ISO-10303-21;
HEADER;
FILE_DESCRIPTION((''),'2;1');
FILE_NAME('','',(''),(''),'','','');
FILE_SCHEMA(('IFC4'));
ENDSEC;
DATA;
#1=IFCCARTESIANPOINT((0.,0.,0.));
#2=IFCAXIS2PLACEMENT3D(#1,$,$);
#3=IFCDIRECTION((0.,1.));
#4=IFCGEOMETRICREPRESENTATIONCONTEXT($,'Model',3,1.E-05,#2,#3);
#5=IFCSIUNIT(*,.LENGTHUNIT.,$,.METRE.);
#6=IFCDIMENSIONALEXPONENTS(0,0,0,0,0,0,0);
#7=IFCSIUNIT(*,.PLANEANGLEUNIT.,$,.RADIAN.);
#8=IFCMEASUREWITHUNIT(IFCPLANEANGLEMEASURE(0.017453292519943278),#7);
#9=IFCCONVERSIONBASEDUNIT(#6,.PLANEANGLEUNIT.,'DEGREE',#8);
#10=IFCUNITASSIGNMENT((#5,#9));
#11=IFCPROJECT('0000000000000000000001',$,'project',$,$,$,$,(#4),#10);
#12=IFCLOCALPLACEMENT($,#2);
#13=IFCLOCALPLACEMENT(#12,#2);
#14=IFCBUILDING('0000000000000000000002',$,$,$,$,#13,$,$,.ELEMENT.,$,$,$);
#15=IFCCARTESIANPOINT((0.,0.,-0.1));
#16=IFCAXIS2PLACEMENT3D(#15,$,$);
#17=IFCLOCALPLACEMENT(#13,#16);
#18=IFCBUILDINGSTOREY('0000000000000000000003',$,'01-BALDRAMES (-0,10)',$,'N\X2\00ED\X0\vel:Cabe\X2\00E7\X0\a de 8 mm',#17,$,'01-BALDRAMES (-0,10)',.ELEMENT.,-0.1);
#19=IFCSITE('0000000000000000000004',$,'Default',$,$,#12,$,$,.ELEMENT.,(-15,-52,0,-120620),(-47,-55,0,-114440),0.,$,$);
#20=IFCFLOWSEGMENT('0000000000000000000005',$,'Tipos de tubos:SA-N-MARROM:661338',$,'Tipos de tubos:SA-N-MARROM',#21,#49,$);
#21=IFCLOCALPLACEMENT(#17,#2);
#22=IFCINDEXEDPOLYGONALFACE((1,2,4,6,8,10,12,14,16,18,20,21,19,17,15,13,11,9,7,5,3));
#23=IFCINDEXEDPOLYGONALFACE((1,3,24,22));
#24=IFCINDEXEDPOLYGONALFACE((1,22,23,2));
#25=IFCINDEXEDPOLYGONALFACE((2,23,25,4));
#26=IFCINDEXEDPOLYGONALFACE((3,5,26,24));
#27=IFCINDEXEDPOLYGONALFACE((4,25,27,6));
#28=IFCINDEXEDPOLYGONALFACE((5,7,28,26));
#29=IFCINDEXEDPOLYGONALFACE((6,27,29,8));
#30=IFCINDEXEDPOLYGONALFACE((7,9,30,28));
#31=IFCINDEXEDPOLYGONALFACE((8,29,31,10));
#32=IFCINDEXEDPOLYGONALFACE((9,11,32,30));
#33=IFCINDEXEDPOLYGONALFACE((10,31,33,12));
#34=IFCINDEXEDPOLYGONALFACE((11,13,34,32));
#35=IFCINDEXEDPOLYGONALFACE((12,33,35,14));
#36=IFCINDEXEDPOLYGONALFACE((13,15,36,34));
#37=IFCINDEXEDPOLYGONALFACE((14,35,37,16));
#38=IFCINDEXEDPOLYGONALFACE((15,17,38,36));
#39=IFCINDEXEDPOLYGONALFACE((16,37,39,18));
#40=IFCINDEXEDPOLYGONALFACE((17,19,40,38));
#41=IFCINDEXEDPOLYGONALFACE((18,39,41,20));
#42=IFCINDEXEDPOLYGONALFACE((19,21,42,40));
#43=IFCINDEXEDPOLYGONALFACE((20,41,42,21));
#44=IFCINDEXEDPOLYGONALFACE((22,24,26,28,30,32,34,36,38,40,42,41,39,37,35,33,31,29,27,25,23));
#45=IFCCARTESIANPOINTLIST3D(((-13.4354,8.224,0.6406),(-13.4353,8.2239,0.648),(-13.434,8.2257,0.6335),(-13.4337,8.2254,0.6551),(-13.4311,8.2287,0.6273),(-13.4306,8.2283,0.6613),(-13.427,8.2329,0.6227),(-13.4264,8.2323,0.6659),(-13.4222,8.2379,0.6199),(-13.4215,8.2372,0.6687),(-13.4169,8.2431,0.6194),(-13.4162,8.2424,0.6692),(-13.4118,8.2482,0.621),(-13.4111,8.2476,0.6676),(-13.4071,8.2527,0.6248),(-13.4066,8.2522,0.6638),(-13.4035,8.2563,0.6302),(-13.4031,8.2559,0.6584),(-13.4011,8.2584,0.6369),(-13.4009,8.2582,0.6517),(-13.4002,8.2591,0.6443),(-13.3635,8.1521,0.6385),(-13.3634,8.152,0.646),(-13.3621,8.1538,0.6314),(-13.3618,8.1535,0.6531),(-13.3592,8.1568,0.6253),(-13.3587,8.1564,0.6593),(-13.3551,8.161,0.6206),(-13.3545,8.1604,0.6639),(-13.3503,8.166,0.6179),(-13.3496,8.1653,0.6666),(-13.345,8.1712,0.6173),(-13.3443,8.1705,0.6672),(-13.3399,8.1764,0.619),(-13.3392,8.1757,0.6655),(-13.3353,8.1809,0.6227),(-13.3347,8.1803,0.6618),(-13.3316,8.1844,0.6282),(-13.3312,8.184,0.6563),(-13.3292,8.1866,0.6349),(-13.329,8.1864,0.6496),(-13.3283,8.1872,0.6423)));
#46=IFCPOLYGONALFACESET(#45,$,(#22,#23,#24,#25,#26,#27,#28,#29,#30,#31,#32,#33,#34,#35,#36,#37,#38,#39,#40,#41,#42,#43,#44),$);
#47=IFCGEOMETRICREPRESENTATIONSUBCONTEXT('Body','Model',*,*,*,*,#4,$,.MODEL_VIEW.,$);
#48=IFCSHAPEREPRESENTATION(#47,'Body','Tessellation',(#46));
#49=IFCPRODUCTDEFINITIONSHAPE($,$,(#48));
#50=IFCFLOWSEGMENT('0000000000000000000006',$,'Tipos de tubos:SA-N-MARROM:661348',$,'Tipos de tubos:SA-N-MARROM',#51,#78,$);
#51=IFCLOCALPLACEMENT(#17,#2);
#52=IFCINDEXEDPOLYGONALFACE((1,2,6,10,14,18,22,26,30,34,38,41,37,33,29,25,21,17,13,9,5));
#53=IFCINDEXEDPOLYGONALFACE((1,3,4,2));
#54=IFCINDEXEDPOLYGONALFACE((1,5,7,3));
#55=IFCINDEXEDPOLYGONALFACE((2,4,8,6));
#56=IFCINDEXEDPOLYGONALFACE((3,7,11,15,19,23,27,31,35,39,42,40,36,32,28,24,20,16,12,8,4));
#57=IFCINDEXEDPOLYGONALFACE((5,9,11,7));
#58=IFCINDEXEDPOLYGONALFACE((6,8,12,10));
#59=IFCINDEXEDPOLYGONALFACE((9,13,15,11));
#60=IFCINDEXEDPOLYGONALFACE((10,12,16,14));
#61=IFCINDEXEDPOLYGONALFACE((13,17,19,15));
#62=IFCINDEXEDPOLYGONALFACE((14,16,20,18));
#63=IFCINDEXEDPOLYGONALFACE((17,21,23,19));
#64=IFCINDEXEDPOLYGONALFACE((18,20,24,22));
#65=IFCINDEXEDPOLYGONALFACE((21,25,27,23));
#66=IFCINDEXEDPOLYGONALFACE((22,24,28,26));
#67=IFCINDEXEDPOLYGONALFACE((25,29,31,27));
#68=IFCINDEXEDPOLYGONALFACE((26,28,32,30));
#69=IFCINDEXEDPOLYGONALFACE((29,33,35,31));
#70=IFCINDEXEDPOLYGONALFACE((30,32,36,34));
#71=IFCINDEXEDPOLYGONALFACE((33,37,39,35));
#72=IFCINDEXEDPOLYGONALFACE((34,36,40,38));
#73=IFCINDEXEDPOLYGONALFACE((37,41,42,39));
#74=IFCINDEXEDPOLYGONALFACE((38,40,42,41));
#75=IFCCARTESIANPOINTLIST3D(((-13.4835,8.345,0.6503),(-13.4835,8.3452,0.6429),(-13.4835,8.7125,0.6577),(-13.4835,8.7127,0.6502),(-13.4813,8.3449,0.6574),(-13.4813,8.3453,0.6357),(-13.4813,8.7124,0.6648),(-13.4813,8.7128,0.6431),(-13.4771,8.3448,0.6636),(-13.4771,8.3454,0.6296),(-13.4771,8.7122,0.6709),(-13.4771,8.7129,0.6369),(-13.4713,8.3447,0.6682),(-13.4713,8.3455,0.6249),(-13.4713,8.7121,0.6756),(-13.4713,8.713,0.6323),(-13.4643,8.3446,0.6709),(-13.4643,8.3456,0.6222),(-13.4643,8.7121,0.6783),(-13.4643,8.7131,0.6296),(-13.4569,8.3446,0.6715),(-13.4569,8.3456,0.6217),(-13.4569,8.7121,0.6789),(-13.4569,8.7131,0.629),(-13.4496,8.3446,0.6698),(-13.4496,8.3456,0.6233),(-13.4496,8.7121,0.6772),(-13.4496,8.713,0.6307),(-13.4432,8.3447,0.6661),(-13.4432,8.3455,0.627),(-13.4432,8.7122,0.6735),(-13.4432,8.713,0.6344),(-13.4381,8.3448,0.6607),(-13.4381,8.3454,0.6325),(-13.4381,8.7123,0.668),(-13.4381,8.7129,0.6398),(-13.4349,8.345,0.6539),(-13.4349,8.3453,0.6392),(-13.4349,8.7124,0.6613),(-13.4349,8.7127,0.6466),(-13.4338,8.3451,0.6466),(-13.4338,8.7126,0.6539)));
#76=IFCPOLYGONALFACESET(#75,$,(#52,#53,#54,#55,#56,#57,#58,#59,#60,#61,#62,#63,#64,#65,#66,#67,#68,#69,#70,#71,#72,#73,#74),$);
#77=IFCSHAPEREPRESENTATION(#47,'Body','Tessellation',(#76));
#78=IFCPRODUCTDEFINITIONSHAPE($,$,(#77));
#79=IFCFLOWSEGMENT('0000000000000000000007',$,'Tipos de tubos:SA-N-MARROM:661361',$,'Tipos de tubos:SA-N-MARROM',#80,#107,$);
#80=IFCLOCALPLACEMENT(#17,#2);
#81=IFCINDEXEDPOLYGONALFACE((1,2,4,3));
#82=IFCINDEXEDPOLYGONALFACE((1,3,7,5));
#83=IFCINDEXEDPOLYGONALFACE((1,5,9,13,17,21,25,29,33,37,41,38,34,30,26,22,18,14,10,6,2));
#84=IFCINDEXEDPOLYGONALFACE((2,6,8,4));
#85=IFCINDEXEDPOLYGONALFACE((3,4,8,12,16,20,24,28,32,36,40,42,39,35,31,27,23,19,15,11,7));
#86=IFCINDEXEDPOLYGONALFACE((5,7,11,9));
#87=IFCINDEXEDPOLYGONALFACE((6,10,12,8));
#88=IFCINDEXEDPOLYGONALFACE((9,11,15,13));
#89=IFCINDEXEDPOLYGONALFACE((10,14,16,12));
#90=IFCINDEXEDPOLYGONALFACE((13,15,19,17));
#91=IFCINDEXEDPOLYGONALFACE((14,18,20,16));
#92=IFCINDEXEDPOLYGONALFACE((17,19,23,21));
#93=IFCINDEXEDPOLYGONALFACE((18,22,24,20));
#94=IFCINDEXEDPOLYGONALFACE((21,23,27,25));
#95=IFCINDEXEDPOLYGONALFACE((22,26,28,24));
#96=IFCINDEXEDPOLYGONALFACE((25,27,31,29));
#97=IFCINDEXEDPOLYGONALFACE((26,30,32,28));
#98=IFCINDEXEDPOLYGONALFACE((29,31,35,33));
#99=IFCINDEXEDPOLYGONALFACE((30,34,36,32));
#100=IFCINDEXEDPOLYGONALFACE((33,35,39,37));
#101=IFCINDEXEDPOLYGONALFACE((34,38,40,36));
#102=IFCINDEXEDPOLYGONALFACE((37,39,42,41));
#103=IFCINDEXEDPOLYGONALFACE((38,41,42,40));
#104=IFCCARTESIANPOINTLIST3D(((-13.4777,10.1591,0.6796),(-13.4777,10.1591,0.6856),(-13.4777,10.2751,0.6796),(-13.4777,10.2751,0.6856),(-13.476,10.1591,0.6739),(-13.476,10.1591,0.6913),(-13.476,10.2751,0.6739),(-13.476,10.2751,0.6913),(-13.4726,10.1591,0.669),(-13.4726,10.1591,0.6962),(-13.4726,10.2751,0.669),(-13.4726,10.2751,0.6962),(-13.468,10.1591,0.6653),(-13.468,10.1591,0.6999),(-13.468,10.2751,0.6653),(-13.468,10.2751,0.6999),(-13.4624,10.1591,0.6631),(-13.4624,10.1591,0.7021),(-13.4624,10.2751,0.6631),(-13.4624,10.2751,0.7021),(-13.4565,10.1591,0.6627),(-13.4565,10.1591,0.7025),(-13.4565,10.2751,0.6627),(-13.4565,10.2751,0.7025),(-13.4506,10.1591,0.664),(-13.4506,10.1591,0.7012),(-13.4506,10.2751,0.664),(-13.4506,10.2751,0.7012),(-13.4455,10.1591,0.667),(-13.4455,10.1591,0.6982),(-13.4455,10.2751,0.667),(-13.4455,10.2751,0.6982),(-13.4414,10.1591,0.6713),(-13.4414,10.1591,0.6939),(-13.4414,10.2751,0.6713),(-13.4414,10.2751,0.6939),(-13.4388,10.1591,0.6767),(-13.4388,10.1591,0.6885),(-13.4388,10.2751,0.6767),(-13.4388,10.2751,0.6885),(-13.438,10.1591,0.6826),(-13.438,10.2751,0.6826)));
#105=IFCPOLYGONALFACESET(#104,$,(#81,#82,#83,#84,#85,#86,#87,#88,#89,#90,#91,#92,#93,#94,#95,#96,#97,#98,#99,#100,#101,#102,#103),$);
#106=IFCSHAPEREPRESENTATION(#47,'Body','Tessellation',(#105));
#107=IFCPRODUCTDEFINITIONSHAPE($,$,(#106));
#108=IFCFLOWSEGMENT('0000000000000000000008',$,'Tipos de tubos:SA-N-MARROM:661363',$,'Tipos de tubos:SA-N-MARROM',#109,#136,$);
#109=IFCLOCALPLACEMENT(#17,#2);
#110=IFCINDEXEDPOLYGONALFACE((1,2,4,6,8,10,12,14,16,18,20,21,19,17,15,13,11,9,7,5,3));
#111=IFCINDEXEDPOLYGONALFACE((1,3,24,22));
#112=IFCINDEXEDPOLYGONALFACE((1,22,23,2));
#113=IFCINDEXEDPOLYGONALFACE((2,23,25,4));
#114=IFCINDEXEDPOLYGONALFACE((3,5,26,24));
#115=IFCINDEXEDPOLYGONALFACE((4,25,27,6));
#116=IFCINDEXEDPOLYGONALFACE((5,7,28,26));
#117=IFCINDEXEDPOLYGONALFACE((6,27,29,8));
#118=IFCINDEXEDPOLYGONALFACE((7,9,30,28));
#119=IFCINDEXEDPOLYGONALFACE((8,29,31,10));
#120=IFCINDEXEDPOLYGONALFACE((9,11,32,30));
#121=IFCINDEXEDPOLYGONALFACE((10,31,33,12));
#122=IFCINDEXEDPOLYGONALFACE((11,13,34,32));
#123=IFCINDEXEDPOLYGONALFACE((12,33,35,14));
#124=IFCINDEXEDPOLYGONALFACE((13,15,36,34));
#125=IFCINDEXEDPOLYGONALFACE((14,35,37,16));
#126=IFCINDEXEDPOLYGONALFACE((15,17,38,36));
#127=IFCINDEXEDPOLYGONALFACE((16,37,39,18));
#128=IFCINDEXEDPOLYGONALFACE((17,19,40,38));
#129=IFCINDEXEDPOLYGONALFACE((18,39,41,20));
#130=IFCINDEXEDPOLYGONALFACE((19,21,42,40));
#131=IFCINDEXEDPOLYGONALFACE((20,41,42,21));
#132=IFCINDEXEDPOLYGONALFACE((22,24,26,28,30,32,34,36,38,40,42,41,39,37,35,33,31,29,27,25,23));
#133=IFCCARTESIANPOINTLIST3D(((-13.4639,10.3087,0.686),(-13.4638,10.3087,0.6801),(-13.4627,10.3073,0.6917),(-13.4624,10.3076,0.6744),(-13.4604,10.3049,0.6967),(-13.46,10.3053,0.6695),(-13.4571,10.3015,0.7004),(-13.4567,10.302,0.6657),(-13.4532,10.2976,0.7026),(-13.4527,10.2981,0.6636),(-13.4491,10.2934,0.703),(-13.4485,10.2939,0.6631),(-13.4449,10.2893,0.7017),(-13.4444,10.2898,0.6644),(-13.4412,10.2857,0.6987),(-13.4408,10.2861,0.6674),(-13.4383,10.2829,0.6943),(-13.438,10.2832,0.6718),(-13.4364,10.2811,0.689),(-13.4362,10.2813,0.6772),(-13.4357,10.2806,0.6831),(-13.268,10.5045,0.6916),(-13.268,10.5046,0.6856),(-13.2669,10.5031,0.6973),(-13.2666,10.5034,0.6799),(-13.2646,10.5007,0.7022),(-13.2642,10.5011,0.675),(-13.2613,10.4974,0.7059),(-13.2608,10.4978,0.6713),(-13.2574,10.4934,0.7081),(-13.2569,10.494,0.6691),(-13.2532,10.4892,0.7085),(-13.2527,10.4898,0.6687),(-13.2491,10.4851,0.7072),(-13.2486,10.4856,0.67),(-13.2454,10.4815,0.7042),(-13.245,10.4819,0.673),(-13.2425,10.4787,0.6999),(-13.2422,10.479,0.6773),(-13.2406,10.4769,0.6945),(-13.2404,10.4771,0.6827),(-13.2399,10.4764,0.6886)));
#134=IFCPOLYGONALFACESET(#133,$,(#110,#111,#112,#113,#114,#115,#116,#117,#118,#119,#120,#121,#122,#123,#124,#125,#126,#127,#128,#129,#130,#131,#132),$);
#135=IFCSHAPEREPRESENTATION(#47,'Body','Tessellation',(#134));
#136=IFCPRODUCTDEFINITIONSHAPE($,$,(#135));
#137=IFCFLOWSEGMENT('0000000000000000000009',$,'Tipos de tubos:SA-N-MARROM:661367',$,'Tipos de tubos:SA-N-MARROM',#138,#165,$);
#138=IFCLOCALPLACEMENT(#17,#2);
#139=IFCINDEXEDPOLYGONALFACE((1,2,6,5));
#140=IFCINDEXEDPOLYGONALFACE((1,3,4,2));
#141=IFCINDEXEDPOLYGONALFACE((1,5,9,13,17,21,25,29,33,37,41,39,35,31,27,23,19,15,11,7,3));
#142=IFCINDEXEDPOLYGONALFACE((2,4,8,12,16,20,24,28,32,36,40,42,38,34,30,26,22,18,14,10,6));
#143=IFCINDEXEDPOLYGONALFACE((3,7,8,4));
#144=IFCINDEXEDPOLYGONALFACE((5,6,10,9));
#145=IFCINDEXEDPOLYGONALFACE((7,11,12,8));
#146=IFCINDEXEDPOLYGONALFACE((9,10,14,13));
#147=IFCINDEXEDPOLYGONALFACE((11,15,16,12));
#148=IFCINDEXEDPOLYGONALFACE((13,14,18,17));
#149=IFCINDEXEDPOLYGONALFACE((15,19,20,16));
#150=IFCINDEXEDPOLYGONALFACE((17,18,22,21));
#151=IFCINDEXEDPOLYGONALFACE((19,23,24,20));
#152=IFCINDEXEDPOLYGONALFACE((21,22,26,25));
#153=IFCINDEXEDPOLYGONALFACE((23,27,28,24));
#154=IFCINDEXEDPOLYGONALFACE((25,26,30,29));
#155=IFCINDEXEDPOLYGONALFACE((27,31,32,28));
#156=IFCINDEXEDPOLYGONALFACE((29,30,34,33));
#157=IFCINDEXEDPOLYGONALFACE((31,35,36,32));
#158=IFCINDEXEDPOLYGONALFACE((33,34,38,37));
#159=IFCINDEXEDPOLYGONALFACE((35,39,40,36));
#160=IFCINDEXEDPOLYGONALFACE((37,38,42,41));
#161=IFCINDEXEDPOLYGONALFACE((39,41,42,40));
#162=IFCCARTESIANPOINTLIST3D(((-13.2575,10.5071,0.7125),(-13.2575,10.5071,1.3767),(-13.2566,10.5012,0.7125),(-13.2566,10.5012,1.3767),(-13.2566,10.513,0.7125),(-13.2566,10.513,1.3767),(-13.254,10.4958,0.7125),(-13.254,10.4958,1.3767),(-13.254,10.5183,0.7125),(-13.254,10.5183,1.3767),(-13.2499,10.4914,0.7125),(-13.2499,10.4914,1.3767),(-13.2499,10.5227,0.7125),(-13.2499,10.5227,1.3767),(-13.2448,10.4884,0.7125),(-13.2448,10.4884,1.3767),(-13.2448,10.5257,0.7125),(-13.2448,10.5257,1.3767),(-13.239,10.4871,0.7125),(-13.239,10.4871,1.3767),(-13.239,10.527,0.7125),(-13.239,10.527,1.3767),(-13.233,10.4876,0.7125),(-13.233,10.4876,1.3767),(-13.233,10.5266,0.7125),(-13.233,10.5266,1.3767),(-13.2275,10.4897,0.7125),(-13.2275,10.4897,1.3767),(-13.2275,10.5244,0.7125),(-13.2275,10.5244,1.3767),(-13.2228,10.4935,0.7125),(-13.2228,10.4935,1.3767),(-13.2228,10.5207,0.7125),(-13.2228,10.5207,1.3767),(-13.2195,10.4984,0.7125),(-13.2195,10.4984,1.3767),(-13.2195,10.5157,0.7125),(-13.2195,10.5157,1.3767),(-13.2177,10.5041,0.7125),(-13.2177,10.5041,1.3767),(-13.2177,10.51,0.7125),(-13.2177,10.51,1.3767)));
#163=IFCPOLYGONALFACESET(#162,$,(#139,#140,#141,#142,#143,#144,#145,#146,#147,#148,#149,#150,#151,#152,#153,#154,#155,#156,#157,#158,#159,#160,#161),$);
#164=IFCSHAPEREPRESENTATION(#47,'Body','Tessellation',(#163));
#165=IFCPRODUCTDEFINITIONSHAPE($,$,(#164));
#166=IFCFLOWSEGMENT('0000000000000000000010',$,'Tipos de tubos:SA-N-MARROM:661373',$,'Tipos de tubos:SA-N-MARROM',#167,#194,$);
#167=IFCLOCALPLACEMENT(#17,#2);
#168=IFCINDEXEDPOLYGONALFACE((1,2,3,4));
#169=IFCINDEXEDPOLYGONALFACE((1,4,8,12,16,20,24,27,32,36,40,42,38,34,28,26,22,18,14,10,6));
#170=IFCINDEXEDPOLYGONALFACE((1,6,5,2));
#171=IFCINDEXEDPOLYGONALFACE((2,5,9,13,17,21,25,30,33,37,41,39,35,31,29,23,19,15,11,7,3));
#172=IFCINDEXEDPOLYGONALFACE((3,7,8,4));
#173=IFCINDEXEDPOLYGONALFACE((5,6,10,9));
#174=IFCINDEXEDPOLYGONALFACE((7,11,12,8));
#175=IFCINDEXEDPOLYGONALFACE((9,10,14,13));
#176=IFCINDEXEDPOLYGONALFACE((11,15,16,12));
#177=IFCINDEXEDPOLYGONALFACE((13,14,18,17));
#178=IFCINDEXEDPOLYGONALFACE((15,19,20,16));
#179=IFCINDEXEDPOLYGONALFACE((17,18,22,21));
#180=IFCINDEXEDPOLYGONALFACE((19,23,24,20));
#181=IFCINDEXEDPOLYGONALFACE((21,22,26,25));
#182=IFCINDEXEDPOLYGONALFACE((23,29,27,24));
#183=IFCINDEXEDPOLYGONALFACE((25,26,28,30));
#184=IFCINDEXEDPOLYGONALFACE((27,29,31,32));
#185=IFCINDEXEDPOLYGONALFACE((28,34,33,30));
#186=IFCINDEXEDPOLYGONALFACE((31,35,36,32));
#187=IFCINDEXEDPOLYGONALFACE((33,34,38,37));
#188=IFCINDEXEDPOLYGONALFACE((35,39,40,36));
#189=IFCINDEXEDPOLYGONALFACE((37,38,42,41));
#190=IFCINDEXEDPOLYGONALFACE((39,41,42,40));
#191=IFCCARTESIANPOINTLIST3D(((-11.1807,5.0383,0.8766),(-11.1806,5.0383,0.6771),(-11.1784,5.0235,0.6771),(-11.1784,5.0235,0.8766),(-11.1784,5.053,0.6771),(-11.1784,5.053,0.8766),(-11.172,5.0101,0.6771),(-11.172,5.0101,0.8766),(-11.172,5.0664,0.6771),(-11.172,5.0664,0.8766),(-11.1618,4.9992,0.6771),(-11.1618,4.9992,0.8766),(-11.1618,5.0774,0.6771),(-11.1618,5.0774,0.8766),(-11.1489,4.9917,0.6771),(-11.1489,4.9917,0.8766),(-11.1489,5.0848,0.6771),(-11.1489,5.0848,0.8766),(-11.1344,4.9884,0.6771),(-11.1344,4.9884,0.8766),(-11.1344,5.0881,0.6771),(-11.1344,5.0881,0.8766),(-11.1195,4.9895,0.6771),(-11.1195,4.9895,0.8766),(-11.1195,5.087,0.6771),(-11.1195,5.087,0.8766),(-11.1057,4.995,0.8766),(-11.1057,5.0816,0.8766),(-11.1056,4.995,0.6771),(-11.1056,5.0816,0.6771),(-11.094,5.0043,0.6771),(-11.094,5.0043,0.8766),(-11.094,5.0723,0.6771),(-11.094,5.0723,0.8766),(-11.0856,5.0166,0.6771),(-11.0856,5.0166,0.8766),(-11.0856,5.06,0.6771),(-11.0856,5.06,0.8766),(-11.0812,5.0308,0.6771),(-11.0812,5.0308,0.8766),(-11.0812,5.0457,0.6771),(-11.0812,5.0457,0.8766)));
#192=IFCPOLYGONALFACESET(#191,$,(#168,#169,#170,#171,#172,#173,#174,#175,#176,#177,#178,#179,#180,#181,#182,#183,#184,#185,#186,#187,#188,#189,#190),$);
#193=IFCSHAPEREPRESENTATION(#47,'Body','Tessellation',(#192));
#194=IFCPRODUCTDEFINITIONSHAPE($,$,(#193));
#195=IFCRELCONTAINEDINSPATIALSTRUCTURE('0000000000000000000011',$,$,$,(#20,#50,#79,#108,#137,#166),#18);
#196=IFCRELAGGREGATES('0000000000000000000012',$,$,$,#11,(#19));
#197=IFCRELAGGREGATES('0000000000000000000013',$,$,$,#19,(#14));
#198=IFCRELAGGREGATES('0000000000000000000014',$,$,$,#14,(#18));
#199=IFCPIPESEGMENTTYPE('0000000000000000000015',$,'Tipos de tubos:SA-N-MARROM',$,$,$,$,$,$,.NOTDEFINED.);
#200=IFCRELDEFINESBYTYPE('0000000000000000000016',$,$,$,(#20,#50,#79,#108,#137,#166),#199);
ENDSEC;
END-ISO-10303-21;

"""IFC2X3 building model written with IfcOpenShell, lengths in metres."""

from ifc_helpers import new_model, entity, si_unit, converted_unit, direction, frame, frame_2d, origin, origin_2d_with_axis, place, context, subcontext, project, spatial, circle, extrude, type_object, element, save


model = new_model("IFC2X3")

# Units and contexts
model_context = context("Model", 3, precision=1e-05, world=origin(), true_north=direction((0.0, 1.0)))
body_context = subcontext(model_context, "Body", "Model", "MODEL_VIEW")
ifc_project = project(units=[si_unit("LENGTHUNIT", "METRE"), converted_unit("PLANEANGLEUNIT", "DEGREE", entity("IfcPlaneAngleMeasure", 0.017453292519943278), si_unit("PLANEANGLEUNIT", "RADIAN"), dimensions=[0, 0, 0, 0, 0, 0, 0])], contexts=[model_context])

# Site, building, storey
site_placement = place(None, origin())
site = spatial("IfcSite", under=ifc_project, at=site_placement, Name="Default", CompositionType="ELEMENT", RefLatitude=(-15, -52, 0, -120620), RefLongitude=(-47, -55, 0, -114440), RefElevation=0.0)
building_placement = place(site_placement, origin())
building = spatial("IfcBuilding", under=site, at=building_placement, CompositionType="ELEMENT")
storey_placement = place(building_placement, frame((0.0, 0.0, -0.1)))
storey = spatial("IfcBuildingStorey", under=building, at=storey_placement, Name="01-BALDRAMES (-0,10)", ObjectType="Nível:Cabeça de 8 mm", LongName="01-BALDRAMES (-0,10)", CompositionType="ELEMENT", Elevation=-0.1)

# Flow segments
pipe_segment_type_1 = type_object("IfcPipeSegmentType", Name="Tipos de tubos:SA-N-MARROM", PredefinedType="NOTDEFINED")
flow_segment_1_placement = place(storey_placement, origin())
element("IfcFlowSegment", 1, at=flow_segment_1_placement, inside=storey, type_object=pipe_segment_type_1, Name="Tipos de tubos:SA-N-MARROM:661338", ObjectType="Tipos de tubos:SA-N-MARROM", context=body_context, shape_type="SweptSolid", body=[
    extrude(circle(Radius=0.025, at=frame_2d((0.0, 0.0), x_axis=(1.0, 0.0))), frame((-13.4179, 8.2415, 0.6443), z_axis=(0.706966, -0.706966, -0.019961), x_axis=(0.707106, 0.707107, 0.0)), (0.0, 0.0, 1.0), 0.1017),
])
flow_segment_2_placement = place(storey_placement, origin())
element("IfcFlowSegment", 2, at=flow_segment_2_placement, inside=storey, type_object=pipe_segment_type_1, Name="Tipos de tubos:SA-N-MARROM:661348", ObjectType="Tipos de tubos:SA-N-MARROM", context=body_context, shape_type="SweptSolid", body=[
    extrude(circle(Radius=0.025, at=frame_2d((0.0, 0.0), x_axis=(1.0, 0.0))), frame((-13.4588, 8.3451, 0.6466), z_axis=(-0.000001, 0.9998, 0.019996), x_axis=(1.0, 0.000001, 0.0)), (0.0, 0.0, 1.0), 0.3675),
])
flow_segment_3_placement = place(storey_placement, origin())
element("IfcFlowSegment", 3, at=flow_segment_3_placement, inside=storey, type_object=pipe_segment_type_1, Name="Tipos de tubos:SA-N-MARROM:661361", ObjectType="Tipos de tubos:SA-N-MARROM", context=body_context, shape_type="SweptSolid", body=[
    extrude(circle(Radius=0.02, at=frame_2d((0.0, 0.0), x_axis=(1.0, 0.0))), frame((-13.458, 10.1591, 0.6826), z_axis=(-0.000001, 1.0, 0.0), x_axis=(1.0, 0.000001, 0.0)), (0.0, 0.0, 1.0), 0.116),
])
flow_segment_4_placement = place(storey_placement, origin())
element("IfcFlowSegment", 4, at=flow_segment_4_placement, inside=storey, type_object=pipe_segment_type_1, Name="Tipos de tubos:SA-N-MARROM:661363", ObjectType="Tipos de tubos:SA-N-MARROM", context=body_context, shape_type="SweptSolid", body=[
    extrude(circle(Radius=0.02, at=origin_2d_with_axis()), frame((-13.4498, 10.2947, 0.6831), z_axis=(0.706965, 0.706966, 0.019996), x_axis=(0.707107, -0.707106, 0.0)), (0.0, 0.0, 1.0), 0.277),
])
flow_segment_5_placement = place(storey_placement, origin())
element("IfcFlowSegment", 5, at=flow_segment_5_placement, inside=storey, type_object=pipe_segment_type_1, Name="Tipos de tubos:SA-N-MARROM:661367", ObjectType="Tipos de tubos:SA-N-MARROM", context=body_context, shape_type="SweptSolid", body=[
    extrude(circle(Radius=0.02, at=origin_2d_with_axis()), frame((-13.2375, 10.5071, 0.7125), z_axis=(0.0, 0.0, 1.0), x_axis=(-1.0, 0.0, 0.0)), (0.0, 0.0, 1.0), 0.6643),
])
flow_segment_6_placement = place(storey_placement, origin())
element("IfcFlowSegment", 6, at=flow_segment_6_placement, inside=storey, type_object=pipe_segment_type_1, Name="Tipos de tubos:SA-N-MARROM:661373", ObjectType="Tipos de tubos:SA-N-MARROM", context=body_context, shape_type="SweptSolid", body=[
    extrude(circle(Radius=0.05, at=frame_2d((0.0, 0.0), x_axis=(1.0, 0.0))), frame((-11.1306, 5.0383, 0.6771), z_axis=(-0.000051, -0.000046, 1.0), x_axis=(-1.0, 0.0, -0.000051)), (0.0, 0.0, 1.0), 0.1995),
])

save(model, "model.ifc")
